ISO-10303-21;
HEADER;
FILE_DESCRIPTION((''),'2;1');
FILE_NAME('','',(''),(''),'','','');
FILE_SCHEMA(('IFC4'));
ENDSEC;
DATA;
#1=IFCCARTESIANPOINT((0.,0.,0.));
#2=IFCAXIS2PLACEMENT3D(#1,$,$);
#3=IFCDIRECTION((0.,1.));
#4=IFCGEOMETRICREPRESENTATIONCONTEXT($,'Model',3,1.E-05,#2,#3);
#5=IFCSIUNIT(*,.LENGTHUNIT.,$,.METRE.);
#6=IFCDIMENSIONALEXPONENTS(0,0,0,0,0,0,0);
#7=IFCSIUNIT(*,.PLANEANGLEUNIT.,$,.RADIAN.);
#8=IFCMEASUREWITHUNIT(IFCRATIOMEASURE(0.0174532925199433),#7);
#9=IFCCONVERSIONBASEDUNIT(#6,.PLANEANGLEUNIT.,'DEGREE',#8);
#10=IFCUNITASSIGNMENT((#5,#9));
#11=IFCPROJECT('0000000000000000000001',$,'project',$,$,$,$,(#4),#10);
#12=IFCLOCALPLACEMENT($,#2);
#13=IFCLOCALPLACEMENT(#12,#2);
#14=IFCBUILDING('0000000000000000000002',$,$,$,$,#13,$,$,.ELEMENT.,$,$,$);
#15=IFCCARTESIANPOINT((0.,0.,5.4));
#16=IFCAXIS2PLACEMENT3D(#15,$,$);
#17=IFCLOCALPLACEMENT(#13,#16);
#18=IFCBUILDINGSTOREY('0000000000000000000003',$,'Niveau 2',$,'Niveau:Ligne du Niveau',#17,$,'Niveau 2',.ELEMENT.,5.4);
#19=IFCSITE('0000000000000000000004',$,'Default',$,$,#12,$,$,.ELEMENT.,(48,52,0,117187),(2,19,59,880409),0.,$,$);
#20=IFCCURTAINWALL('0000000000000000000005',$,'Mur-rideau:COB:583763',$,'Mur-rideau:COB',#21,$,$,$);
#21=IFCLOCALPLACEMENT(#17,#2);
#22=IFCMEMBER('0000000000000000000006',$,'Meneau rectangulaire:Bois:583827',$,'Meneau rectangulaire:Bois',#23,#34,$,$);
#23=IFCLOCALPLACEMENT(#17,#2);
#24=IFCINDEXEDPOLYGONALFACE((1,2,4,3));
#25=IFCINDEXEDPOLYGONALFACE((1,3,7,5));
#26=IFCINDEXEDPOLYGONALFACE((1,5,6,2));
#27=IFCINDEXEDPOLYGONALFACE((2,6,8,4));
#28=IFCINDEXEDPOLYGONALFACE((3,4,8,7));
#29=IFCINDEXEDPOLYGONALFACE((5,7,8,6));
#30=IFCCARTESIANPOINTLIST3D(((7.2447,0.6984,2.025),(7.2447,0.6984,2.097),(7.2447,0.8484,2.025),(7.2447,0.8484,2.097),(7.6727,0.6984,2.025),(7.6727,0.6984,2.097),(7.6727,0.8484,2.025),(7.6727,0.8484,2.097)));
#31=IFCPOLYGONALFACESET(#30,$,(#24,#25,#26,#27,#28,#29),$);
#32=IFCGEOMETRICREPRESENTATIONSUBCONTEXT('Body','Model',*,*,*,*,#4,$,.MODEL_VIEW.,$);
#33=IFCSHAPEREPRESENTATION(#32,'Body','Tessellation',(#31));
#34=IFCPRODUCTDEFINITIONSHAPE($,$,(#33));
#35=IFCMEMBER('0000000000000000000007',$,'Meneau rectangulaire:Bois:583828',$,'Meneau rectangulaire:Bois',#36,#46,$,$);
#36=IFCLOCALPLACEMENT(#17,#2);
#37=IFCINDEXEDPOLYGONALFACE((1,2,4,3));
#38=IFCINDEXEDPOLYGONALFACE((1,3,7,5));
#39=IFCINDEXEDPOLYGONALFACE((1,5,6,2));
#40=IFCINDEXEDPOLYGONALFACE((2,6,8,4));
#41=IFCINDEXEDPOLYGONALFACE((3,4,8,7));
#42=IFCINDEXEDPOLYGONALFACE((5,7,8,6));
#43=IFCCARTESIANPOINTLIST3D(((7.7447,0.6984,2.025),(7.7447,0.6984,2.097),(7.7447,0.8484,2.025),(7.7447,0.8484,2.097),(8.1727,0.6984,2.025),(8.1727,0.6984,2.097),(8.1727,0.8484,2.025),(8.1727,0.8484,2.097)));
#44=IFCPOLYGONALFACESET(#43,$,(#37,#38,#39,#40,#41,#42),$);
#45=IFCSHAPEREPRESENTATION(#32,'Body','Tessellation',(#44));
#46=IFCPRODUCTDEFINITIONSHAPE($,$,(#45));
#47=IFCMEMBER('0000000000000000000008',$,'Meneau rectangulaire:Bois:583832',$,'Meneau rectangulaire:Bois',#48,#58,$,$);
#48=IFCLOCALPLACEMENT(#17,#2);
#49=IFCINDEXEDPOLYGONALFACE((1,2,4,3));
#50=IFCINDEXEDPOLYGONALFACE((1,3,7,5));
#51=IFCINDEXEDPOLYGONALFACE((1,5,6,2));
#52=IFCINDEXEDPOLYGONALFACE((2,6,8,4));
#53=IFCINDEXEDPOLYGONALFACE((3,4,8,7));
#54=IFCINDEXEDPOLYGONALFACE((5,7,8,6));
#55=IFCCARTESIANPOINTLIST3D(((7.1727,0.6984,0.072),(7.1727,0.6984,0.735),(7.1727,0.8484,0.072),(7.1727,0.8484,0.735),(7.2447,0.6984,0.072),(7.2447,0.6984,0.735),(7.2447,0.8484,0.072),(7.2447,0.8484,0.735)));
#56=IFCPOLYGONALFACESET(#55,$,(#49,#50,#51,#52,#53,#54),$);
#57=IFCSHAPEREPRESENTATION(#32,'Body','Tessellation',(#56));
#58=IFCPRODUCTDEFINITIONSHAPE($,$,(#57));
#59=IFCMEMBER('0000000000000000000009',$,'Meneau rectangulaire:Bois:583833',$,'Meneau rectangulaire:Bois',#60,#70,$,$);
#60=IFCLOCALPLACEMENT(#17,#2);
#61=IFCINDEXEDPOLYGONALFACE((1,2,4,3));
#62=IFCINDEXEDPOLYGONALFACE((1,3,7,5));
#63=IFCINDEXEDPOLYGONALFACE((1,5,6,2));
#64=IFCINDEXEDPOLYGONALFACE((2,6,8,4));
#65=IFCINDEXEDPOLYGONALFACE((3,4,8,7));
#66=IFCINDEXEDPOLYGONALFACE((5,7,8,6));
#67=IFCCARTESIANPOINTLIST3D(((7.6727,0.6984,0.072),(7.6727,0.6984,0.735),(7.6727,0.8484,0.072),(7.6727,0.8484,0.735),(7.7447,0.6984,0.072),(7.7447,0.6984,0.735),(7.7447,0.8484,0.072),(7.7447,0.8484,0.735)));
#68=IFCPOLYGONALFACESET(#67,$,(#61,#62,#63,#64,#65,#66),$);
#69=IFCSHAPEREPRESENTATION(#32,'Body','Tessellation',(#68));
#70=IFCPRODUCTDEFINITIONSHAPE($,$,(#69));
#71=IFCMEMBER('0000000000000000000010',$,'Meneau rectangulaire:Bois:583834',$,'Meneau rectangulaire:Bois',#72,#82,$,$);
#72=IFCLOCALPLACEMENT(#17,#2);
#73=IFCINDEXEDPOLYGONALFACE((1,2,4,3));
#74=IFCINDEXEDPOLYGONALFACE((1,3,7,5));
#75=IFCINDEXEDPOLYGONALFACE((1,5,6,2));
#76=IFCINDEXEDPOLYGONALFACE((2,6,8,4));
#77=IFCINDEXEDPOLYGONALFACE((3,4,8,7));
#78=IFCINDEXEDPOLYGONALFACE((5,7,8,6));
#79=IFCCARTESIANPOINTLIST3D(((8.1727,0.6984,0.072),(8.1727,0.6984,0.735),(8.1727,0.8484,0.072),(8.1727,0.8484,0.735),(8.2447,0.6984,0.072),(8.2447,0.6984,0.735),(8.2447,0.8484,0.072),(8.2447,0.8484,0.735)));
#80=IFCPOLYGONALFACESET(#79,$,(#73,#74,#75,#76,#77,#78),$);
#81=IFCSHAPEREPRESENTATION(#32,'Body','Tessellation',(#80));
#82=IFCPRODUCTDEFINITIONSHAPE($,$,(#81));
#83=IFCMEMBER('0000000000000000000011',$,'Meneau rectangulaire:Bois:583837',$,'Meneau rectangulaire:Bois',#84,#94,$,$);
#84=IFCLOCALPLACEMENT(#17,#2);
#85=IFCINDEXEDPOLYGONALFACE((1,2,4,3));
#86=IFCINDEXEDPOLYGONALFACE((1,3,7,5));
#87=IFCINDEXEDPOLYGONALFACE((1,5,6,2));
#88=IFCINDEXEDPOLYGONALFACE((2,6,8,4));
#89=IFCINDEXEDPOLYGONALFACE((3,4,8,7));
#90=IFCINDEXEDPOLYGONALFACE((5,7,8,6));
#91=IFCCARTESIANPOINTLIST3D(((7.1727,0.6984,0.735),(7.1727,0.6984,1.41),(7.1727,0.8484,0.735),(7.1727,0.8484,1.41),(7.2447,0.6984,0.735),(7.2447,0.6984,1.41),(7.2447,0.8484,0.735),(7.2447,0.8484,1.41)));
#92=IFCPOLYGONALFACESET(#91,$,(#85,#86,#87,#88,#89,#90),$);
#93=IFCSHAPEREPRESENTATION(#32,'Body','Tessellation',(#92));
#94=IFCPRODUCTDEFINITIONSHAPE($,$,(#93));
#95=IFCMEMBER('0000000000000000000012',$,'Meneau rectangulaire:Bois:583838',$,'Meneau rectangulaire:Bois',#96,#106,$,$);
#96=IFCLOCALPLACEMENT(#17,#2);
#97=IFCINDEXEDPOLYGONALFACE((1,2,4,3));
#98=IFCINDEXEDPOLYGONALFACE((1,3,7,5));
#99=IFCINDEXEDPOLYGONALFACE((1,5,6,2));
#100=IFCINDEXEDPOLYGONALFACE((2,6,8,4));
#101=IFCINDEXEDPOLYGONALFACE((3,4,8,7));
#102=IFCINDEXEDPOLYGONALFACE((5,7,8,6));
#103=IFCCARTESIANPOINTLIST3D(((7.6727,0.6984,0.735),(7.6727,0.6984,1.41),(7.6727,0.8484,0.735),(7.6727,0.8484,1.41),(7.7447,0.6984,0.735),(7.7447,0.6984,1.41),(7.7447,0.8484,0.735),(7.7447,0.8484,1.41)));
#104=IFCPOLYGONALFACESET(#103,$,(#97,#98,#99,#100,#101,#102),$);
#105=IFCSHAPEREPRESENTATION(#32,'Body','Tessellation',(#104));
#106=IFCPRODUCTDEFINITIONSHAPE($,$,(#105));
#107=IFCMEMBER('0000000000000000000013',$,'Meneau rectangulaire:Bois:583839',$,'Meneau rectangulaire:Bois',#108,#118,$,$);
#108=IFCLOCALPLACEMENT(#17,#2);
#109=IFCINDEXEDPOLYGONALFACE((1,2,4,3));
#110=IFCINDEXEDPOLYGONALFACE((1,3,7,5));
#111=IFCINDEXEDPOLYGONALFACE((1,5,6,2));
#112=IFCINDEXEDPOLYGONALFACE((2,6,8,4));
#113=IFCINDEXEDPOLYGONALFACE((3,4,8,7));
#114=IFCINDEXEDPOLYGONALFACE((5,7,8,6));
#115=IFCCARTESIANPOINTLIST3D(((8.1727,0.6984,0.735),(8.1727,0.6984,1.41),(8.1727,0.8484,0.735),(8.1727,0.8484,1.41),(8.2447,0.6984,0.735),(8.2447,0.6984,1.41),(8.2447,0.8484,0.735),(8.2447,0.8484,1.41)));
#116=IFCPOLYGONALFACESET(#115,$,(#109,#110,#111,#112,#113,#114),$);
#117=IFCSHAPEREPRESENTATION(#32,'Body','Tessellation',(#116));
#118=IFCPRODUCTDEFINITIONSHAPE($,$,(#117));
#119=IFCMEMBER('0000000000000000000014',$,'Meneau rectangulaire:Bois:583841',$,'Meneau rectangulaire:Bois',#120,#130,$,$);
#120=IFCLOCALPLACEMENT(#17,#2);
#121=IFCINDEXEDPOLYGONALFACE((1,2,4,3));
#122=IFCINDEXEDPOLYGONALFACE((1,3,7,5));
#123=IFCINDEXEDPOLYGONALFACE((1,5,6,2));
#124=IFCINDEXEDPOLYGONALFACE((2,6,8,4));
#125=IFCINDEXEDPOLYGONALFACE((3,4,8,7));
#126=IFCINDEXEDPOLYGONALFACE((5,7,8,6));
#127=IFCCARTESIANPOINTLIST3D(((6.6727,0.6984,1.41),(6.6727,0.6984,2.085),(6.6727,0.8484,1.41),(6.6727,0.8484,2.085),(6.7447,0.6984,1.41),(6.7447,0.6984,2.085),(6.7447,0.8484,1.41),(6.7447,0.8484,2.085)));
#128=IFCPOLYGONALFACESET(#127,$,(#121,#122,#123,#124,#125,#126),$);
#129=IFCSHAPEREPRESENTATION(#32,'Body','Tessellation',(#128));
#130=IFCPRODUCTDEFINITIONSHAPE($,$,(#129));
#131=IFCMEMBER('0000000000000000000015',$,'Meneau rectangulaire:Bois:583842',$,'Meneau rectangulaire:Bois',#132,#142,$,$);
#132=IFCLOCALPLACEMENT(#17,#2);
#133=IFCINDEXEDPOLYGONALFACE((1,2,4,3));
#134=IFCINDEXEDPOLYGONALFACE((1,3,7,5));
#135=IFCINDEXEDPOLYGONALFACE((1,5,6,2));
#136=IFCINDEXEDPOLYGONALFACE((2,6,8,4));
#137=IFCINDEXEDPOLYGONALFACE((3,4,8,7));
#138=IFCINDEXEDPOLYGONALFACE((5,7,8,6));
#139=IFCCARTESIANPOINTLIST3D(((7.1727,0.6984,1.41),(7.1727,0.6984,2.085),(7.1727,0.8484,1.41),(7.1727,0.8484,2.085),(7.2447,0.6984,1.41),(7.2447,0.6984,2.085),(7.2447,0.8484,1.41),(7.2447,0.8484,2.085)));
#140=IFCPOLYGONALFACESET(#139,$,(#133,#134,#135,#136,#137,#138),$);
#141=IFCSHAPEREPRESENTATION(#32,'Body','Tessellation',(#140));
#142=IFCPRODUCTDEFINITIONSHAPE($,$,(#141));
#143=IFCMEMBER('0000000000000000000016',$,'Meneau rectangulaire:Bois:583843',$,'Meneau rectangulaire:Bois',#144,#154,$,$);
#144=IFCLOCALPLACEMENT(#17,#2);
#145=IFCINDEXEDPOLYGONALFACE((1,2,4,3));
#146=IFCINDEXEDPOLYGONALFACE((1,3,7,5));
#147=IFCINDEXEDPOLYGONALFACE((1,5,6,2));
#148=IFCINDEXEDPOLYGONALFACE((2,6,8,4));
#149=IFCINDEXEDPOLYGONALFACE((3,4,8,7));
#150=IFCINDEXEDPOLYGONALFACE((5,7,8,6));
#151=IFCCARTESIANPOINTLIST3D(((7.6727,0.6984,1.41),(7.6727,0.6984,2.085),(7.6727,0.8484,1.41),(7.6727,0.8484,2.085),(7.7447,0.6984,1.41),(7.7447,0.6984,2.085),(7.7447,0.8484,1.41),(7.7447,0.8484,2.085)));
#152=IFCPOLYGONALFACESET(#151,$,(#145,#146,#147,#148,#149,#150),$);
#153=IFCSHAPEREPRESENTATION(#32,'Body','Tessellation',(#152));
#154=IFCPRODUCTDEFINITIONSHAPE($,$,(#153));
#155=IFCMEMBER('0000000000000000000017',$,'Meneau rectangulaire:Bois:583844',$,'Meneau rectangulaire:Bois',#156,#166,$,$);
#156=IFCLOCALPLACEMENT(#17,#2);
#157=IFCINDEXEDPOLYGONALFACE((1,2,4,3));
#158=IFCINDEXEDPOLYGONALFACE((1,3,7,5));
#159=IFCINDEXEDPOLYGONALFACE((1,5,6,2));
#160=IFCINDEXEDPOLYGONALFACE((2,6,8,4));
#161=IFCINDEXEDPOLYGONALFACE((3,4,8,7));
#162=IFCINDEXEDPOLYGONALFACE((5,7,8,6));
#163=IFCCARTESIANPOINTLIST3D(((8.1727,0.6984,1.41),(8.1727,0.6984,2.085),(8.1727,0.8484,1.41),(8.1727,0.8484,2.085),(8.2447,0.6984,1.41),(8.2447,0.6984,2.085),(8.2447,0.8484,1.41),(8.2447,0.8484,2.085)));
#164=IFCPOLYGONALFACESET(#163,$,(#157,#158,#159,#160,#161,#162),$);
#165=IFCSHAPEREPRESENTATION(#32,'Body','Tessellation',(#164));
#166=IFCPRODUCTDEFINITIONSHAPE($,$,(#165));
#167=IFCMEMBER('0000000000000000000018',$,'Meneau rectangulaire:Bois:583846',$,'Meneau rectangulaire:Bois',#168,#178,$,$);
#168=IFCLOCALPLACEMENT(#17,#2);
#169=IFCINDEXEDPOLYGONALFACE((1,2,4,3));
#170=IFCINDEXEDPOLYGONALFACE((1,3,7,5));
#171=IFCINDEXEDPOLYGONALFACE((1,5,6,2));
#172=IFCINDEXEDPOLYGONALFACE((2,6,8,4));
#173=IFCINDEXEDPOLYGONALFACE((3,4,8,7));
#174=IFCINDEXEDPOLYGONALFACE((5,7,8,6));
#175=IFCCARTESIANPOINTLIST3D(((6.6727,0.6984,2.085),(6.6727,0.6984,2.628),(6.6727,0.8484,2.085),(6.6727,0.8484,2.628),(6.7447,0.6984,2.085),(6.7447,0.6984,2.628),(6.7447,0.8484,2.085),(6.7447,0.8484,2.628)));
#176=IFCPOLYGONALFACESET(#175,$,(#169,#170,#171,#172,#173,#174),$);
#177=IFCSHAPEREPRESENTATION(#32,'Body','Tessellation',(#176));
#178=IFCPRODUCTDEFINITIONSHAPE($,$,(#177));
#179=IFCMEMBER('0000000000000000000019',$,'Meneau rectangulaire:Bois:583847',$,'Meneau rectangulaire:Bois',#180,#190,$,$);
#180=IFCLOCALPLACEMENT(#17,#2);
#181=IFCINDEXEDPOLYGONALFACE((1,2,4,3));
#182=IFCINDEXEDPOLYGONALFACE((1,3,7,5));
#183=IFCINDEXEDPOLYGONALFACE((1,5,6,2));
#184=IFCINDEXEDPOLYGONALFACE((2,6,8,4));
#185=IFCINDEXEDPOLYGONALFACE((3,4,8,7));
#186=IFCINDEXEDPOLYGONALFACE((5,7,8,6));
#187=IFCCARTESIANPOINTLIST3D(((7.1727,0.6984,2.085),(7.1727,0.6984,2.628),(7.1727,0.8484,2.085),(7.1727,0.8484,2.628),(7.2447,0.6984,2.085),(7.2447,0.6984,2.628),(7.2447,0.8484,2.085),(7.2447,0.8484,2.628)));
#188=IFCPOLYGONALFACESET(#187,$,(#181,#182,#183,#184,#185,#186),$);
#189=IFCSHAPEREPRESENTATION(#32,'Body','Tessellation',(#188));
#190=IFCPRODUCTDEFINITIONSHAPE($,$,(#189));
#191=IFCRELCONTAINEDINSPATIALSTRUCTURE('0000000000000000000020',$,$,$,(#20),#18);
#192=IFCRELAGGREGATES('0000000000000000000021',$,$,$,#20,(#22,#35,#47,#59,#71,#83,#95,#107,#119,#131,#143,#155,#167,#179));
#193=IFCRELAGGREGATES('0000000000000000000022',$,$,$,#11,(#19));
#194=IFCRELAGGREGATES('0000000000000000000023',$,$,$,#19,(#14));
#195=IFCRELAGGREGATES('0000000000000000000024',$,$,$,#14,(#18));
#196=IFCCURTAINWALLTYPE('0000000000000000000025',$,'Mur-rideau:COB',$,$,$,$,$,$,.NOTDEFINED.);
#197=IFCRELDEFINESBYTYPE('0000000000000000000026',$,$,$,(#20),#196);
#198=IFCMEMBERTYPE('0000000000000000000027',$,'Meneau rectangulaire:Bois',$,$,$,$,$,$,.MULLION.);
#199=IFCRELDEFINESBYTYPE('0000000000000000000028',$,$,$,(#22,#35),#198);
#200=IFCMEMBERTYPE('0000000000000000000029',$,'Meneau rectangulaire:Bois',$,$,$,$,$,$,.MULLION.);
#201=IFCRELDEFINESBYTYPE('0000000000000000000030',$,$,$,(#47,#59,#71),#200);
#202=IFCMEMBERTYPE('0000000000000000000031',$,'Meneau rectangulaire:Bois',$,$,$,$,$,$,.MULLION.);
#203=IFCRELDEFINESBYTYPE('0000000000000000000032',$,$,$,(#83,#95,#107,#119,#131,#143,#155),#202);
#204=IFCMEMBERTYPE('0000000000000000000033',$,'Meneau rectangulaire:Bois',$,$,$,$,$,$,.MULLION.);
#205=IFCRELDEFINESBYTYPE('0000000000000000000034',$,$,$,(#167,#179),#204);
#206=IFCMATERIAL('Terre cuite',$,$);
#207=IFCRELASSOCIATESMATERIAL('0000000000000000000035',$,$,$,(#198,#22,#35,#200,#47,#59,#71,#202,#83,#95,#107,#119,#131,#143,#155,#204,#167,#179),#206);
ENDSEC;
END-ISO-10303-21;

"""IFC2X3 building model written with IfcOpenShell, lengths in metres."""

from ifc_helpers import new_model, entity, si_unit, converted_unit, direction, frame, origin, origin_2d_with_axis, place, context, subcontext, project, spatial, rectangle, extrude, source, transform, mapped, material, type_object, type_shapes, element, aggregate, save


model = new_model("IFC2X3")

# Units and contexts
model_context = context("Model", 3, precision=1e-05, world=origin(), true_north=direction((0.0, 1.0)))
body_context = subcontext(model_context, "Body", "Model", "MODEL_VIEW")
ifc_project = project(units=[si_unit("LENGTHUNIT", "METRE"), converted_unit("PLANEANGLEUNIT", "DEGREE", entity("IfcRatioMeasure", 0.0174532925199433), si_unit("PLANEANGLEUNIT", "RADIAN"), dimensions=[0, 0, 0, 0, 0, 0, 0])], contexts=[model_context])

# Site, building, storey
site_placement = place(None, origin())
site = spatial("IfcSite", under=ifc_project, at=site_placement, Name="Default", CompositionType="ELEMENT", RefLatitude=(48, 52, 0, 117187), RefLongitude=(2, 19, 59, 880409), RefElevation=0.0)
building_placement = place(site_placement, origin())
building = spatial("IfcBuilding", under=site, at=building_placement, CompositionType="ELEMENT")
storey_placement = place(building_placement, frame((0.0, 0.0, 5.4)))
storey = spatial("IfcBuildingStorey", under=building, at=storey_placement, Name="Niveau 2", ObjectType="Niveau:Ligne du Niveau", LongName="Niveau 2", CompositionType="ELEMENT", Elevation=5.4)

# Curtain wall, members
curtain_wall_type_1 = type_object("IfcCurtainWallType", Name="Mur-rideau:COB", PredefinedType="NOTDEFINED")
curtain_wall_1_placement = place(storey_placement, frame((0.0, 0.0, -5.4)))
curtain_wall_1 = element("IfcCurtainWall", 1, at=curtain_wall_1_placement, inside=storey, type_object=curtain_wall_type_1, Name="Mur-rideau:COB:583763", ObjectType="Mur-rideau:COB")
ifc_material_1 = material(Name="Terre cuite")
member_type_1 = type_object("IfcMemberType", Name="Meneau rectangulaire:Bois", PredefinedType="MULLION", material=ifc_material_1)
shared_shape_1 = source(origin(), body_context, "Body", "SweptSolid", [
    extrude(rectangle(XDim=0.15, YDim=0.072, at=origin_2d_with_axis()), frame((-0.024, 0.0, -0.428), z_axis=(0.0, 0.0, 1.0), x_axis=(0.0, -1.0, 0.0)), (0.0, 0.0, 1.0), 0.428),
])
type_shapes(member_type_1, [shared_shape_1])
member_1_placement = place(storey_placement, frame((7.6727, 0.7734, 2.085), z_axis=(1.0, 0.0, 0.0), x_axis=(0.0, 0.0, 1.0)))
member_1 = element("IfcMember", 2, at=member_1_placement, type_object=member_type_1, material=ifc_material_1, Name="Meneau rectangulaire:Bois:583827", ObjectType="Meneau rectangulaire:Bois", context=body_context, shape_type="MappedRepresentation", body=[
    mapped(shared_shape_1, transform((0.0, 0.0, 0.0), scale=1.0)),
])
member_2_placement = place(storey_placement, frame((8.1727, 0.7734, 2.085), z_axis=(1.0, 0.0, 0.0), x_axis=(0.0, 0.0, 1.0)))
member_2 = element("IfcMember", 3, at=member_2_placement, type_object=member_type_1, material=ifc_material_1, Name="Meneau rectangulaire:Bois:583828", ObjectType="Meneau rectangulaire:Bois", context=body_context, shape_type="MappedRepresentation", body=[
    mapped(shared_shape_1, transform((0.0, 0.0, 0.0), scale=1.0)),
])
member_type_2 = type_object("IfcMemberType", Name="Meneau rectangulaire:Bois", PredefinedType="MULLION", material=ifc_material_1)
shared_shape_2 = source(origin(), body_context, "Body", "SweptSolid", [
    extrude(rectangle(XDim=0.15, YDim=0.072, at=origin_2d_with_axis()), frame((-0.024, 0.0, -0.663), z_axis=(0.0, 0.0, 1.0), x_axis=(0.0, -1.0, 0.0)), (0.0, 0.0, 1.0), 0.663),
])
type_shapes(member_type_2, [shared_shape_2])
member_3_placement = place(storey_placement, frame((7.2327, 0.7734, 0.072), z_axis=(0.0, 0.0, -1.0), x_axis=(1.0, 0.0, 0.0)))
member_3 = element("IfcMember", 4, at=member_3_placement, type_object=member_type_2, material=ifc_material_1, Name="Meneau rectangulaire:Bois:583832", ObjectType="Meneau rectangulaire:Bois", context=body_context, shape_type="MappedRepresentation", body=[
    mapped(shared_shape_2, transform((0.0, 0.0, 0.0), scale=1.0)),
])
member_4_placement = place(storey_placement, frame((7.7327, 0.7734, 0.072), z_axis=(0.0, 0.0, -1.0), x_axis=(1.0, 0.0, 0.0)))
member_4 = element("IfcMember", 5, at=member_4_placement, type_object=member_type_2, material=ifc_material_1, Name="Meneau rectangulaire:Bois:583833", ObjectType="Meneau rectangulaire:Bois", context=body_context, shape_type="MappedRepresentation", body=[
    mapped(shared_shape_2, transform((0.0, 0.0, 0.0), scale=1.0)),
])
member_5_placement = place(storey_placement, frame((8.2327, 0.7734, 0.072), z_axis=(0.0, 0.0, -1.0), x_axis=(1.0, 0.0, 0.0)))
member_5 = element("IfcMember", 6, at=member_5_placement, type_object=member_type_2, material=ifc_material_1, Name="Meneau rectangulaire:Bois:583834", ObjectType="Meneau rectangulaire:Bois", context=body_context, shape_type="MappedRepresentation", body=[
    mapped(shared_shape_2, transform((0.0, 0.0, 0.0), scale=1.0)),
])
member_type_3 = type_object("IfcMemberType", Name="Meneau rectangulaire:Bois", PredefinedType="MULLION", material=ifc_material_1)
shared_shape_3 = source(origin(), body_context, "Body", "SweptSolid", [
    extrude(rectangle(XDim=0.15, YDim=0.072, at=origin_2d_with_axis()), frame((-0.024, 0.0, -0.675), z_axis=(0.0, 0.0, 1.0), x_axis=(0.0, -1.0, 0.0)), (0.0, 0.0, 1.0), 0.675),
])
type_shapes(member_type_3, [shared_shape_3])
member_6_placement = place(storey_placement, frame((7.2327, 0.7734, 0.735), z_axis=(0.0, 0.0, -1.0), x_axis=(1.0, 0.0, 0.0)))
member_6 = element("IfcMember", 7, at=member_6_placement, type_object=member_type_3, material=ifc_material_1, Name="Meneau rectangulaire:Bois:583837", ObjectType="Meneau rectangulaire:Bois", context=body_context, shape_type="MappedRepresentation", body=[
    mapped(shared_shape_3, transform((0.0, 0.0, 0.0), scale=1.0)),
])
member_7_placement = place(storey_placement, frame((7.7327, 0.7734, 0.735), z_axis=(0.0, 0.0, -1.0), x_axis=(1.0, 0.0, 0.0)))
member_7 = element("IfcMember", 8, at=member_7_placement, type_object=member_type_3, material=ifc_material_1, Name="Meneau rectangulaire:Bois:583838", ObjectType="Meneau rectangulaire:Bois", context=body_context, shape_type="MappedRepresentation", body=[
    mapped(shared_shape_3, transform((0.0, 0.0, 0.0), scale=1.0)),
])
member_8_placement = place(storey_placement, frame((8.2327, 0.7734, 0.735), z_axis=(0.0, 0.0, -1.0), x_axis=(1.0, 0.0, 0.0)))
member_8 = element("IfcMember", 9, at=member_8_placement, type_object=member_type_3, material=ifc_material_1, Name="Meneau rectangulaire:Bois:583839", ObjectType="Meneau rectangulaire:Bois", context=body_context, shape_type="MappedRepresentation", body=[
    mapped(shared_shape_3, transform((0.0, 0.0, 0.0), scale=1.0)),
])
member_9_placement = place(storey_placement, frame((6.7327, 0.7734, 1.41), z_axis=(0.0, 0.0, -1.0), x_axis=(1.0, 0.0, 0.0)))
member_9 = element("IfcMember", 10, at=member_9_placement, type_object=member_type_3, material=ifc_material_1, Name="Meneau rectangulaire:Bois:583841", ObjectType="Meneau rectangulaire:Bois", context=body_context, shape_type="MappedRepresentation", body=[
    mapped(shared_shape_3, transform((0.0, 0.0, 0.0), scale=1.0)),
])
member_10_placement = place(storey_placement, frame((7.2327, 0.7734, 1.41), z_axis=(0.0, 0.0, -1.0), x_axis=(1.0, 0.0, 0.0)))
member_10 = element("IfcMember", 11, at=member_10_placement, type_object=member_type_3, material=ifc_material_1, Name="Meneau rectangulaire:Bois:583842", ObjectType="Meneau rectangulaire:Bois", context=body_context, shape_type="MappedRepresentation", body=[
    mapped(shared_shape_3, transform((0.0, 0.0, 0.0), scale=1.0)),
])
member_11_placement = place(storey_placement, frame((7.7327, 0.7734, 1.41), z_axis=(0.0, 0.0, -1.0), x_axis=(1.0, 0.0, 0.0)))
member_11 = element("IfcMember", 12, at=member_11_placement, type_object=member_type_3, material=ifc_material_1, Name="Meneau rectangulaire:Bois:583843", ObjectType="Meneau rectangulaire:Bois", context=body_context, shape_type="MappedRepresentation", body=[
    mapped(shared_shape_3, transform((0.0, 0.0, 0.0), scale=1.0)),
])
member_12_placement = place(storey_placement, frame((8.2327, 0.7734, 1.41), z_axis=(0.0, 0.0, -1.0), x_axis=(1.0, 0.0, 0.0)))
member_12 = element("IfcMember", 13, at=member_12_placement, type_object=member_type_3, material=ifc_material_1, Name="Meneau rectangulaire:Bois:583844", ObjectType="Meneau rectangulaire:Bois", context=body_context, shape_type="MappedRepresentation", body=[
    mapped(shared_shape_3, transform((0.0, 0.0, 0.0), scale=1.0)),
])
member_type_4 = type_object("IfcMemberType", Name="Meneau rectangulaire:Bois", PredefinedType="MULLION", material=ifc_material_1)
shared_shape_4 = source(origin(), body_context, "Body", "SweptSolid", [
    extrude(rectangle(XDim=0.15, YDim=0.072, at=origin_2d_with_axis()), frame((-0.024, 0.0, -0.543), z_axis=(0.0, 0.0, 1.0), x_axis=(0.0, -1.0, 0.0)), (0.0, 0.0, 1.0), 0.543),
])
type_shapes(member_type_4, [shared_shape_4])
member_13_placement = place(storey_placement, frame((6.7327, 0.7734, 2.085), z_axis=(0.0, 0.0, -1.0), x_axis=(1.0, 0.0, 0.0)))
member_13 = element("IfcMember", 14, at=member_13_placement, type_object=member_type_4, material=ifc_material_1, Name="Meneau rectangulaire:Bois:583846", ObjectType="Meneau rectangulaire:Bois", context=body_context, shape_type="MappedRepresentation", body=[
    mapped(shared_shape_4, transform((0.0, 0.0, 0.0), scale=1.0)),
])
member_14_placement = place(storey_placement, frame((7.2327, 0.7734, 2.085), z_axis=(0.0, 0.0, -1.0), x_axis=(1.0, 0.0, 0.0)))
member_14 = element("IfcMember", 15, at=member_14_placement, type_object=member_type_4, material=ifc_material_1, Name="Meneau rectangulaire:Bois:583847", ObjectType="Meneau rectangulaire:Bois", context=body_context, shape_type="MappedRepresentation", body=[
    mapped(shared_shape_4, transform((0.0, 0.0, 0.0), scale=1.0)),
])
aggregate(curtain_wall_1, [member_1, member_2, member_3, member_4, member_5, member_6, member_7, member_8, member_9, member_10, member_11, member_12, member_13, member_14])

save(model, "model.ifc")
